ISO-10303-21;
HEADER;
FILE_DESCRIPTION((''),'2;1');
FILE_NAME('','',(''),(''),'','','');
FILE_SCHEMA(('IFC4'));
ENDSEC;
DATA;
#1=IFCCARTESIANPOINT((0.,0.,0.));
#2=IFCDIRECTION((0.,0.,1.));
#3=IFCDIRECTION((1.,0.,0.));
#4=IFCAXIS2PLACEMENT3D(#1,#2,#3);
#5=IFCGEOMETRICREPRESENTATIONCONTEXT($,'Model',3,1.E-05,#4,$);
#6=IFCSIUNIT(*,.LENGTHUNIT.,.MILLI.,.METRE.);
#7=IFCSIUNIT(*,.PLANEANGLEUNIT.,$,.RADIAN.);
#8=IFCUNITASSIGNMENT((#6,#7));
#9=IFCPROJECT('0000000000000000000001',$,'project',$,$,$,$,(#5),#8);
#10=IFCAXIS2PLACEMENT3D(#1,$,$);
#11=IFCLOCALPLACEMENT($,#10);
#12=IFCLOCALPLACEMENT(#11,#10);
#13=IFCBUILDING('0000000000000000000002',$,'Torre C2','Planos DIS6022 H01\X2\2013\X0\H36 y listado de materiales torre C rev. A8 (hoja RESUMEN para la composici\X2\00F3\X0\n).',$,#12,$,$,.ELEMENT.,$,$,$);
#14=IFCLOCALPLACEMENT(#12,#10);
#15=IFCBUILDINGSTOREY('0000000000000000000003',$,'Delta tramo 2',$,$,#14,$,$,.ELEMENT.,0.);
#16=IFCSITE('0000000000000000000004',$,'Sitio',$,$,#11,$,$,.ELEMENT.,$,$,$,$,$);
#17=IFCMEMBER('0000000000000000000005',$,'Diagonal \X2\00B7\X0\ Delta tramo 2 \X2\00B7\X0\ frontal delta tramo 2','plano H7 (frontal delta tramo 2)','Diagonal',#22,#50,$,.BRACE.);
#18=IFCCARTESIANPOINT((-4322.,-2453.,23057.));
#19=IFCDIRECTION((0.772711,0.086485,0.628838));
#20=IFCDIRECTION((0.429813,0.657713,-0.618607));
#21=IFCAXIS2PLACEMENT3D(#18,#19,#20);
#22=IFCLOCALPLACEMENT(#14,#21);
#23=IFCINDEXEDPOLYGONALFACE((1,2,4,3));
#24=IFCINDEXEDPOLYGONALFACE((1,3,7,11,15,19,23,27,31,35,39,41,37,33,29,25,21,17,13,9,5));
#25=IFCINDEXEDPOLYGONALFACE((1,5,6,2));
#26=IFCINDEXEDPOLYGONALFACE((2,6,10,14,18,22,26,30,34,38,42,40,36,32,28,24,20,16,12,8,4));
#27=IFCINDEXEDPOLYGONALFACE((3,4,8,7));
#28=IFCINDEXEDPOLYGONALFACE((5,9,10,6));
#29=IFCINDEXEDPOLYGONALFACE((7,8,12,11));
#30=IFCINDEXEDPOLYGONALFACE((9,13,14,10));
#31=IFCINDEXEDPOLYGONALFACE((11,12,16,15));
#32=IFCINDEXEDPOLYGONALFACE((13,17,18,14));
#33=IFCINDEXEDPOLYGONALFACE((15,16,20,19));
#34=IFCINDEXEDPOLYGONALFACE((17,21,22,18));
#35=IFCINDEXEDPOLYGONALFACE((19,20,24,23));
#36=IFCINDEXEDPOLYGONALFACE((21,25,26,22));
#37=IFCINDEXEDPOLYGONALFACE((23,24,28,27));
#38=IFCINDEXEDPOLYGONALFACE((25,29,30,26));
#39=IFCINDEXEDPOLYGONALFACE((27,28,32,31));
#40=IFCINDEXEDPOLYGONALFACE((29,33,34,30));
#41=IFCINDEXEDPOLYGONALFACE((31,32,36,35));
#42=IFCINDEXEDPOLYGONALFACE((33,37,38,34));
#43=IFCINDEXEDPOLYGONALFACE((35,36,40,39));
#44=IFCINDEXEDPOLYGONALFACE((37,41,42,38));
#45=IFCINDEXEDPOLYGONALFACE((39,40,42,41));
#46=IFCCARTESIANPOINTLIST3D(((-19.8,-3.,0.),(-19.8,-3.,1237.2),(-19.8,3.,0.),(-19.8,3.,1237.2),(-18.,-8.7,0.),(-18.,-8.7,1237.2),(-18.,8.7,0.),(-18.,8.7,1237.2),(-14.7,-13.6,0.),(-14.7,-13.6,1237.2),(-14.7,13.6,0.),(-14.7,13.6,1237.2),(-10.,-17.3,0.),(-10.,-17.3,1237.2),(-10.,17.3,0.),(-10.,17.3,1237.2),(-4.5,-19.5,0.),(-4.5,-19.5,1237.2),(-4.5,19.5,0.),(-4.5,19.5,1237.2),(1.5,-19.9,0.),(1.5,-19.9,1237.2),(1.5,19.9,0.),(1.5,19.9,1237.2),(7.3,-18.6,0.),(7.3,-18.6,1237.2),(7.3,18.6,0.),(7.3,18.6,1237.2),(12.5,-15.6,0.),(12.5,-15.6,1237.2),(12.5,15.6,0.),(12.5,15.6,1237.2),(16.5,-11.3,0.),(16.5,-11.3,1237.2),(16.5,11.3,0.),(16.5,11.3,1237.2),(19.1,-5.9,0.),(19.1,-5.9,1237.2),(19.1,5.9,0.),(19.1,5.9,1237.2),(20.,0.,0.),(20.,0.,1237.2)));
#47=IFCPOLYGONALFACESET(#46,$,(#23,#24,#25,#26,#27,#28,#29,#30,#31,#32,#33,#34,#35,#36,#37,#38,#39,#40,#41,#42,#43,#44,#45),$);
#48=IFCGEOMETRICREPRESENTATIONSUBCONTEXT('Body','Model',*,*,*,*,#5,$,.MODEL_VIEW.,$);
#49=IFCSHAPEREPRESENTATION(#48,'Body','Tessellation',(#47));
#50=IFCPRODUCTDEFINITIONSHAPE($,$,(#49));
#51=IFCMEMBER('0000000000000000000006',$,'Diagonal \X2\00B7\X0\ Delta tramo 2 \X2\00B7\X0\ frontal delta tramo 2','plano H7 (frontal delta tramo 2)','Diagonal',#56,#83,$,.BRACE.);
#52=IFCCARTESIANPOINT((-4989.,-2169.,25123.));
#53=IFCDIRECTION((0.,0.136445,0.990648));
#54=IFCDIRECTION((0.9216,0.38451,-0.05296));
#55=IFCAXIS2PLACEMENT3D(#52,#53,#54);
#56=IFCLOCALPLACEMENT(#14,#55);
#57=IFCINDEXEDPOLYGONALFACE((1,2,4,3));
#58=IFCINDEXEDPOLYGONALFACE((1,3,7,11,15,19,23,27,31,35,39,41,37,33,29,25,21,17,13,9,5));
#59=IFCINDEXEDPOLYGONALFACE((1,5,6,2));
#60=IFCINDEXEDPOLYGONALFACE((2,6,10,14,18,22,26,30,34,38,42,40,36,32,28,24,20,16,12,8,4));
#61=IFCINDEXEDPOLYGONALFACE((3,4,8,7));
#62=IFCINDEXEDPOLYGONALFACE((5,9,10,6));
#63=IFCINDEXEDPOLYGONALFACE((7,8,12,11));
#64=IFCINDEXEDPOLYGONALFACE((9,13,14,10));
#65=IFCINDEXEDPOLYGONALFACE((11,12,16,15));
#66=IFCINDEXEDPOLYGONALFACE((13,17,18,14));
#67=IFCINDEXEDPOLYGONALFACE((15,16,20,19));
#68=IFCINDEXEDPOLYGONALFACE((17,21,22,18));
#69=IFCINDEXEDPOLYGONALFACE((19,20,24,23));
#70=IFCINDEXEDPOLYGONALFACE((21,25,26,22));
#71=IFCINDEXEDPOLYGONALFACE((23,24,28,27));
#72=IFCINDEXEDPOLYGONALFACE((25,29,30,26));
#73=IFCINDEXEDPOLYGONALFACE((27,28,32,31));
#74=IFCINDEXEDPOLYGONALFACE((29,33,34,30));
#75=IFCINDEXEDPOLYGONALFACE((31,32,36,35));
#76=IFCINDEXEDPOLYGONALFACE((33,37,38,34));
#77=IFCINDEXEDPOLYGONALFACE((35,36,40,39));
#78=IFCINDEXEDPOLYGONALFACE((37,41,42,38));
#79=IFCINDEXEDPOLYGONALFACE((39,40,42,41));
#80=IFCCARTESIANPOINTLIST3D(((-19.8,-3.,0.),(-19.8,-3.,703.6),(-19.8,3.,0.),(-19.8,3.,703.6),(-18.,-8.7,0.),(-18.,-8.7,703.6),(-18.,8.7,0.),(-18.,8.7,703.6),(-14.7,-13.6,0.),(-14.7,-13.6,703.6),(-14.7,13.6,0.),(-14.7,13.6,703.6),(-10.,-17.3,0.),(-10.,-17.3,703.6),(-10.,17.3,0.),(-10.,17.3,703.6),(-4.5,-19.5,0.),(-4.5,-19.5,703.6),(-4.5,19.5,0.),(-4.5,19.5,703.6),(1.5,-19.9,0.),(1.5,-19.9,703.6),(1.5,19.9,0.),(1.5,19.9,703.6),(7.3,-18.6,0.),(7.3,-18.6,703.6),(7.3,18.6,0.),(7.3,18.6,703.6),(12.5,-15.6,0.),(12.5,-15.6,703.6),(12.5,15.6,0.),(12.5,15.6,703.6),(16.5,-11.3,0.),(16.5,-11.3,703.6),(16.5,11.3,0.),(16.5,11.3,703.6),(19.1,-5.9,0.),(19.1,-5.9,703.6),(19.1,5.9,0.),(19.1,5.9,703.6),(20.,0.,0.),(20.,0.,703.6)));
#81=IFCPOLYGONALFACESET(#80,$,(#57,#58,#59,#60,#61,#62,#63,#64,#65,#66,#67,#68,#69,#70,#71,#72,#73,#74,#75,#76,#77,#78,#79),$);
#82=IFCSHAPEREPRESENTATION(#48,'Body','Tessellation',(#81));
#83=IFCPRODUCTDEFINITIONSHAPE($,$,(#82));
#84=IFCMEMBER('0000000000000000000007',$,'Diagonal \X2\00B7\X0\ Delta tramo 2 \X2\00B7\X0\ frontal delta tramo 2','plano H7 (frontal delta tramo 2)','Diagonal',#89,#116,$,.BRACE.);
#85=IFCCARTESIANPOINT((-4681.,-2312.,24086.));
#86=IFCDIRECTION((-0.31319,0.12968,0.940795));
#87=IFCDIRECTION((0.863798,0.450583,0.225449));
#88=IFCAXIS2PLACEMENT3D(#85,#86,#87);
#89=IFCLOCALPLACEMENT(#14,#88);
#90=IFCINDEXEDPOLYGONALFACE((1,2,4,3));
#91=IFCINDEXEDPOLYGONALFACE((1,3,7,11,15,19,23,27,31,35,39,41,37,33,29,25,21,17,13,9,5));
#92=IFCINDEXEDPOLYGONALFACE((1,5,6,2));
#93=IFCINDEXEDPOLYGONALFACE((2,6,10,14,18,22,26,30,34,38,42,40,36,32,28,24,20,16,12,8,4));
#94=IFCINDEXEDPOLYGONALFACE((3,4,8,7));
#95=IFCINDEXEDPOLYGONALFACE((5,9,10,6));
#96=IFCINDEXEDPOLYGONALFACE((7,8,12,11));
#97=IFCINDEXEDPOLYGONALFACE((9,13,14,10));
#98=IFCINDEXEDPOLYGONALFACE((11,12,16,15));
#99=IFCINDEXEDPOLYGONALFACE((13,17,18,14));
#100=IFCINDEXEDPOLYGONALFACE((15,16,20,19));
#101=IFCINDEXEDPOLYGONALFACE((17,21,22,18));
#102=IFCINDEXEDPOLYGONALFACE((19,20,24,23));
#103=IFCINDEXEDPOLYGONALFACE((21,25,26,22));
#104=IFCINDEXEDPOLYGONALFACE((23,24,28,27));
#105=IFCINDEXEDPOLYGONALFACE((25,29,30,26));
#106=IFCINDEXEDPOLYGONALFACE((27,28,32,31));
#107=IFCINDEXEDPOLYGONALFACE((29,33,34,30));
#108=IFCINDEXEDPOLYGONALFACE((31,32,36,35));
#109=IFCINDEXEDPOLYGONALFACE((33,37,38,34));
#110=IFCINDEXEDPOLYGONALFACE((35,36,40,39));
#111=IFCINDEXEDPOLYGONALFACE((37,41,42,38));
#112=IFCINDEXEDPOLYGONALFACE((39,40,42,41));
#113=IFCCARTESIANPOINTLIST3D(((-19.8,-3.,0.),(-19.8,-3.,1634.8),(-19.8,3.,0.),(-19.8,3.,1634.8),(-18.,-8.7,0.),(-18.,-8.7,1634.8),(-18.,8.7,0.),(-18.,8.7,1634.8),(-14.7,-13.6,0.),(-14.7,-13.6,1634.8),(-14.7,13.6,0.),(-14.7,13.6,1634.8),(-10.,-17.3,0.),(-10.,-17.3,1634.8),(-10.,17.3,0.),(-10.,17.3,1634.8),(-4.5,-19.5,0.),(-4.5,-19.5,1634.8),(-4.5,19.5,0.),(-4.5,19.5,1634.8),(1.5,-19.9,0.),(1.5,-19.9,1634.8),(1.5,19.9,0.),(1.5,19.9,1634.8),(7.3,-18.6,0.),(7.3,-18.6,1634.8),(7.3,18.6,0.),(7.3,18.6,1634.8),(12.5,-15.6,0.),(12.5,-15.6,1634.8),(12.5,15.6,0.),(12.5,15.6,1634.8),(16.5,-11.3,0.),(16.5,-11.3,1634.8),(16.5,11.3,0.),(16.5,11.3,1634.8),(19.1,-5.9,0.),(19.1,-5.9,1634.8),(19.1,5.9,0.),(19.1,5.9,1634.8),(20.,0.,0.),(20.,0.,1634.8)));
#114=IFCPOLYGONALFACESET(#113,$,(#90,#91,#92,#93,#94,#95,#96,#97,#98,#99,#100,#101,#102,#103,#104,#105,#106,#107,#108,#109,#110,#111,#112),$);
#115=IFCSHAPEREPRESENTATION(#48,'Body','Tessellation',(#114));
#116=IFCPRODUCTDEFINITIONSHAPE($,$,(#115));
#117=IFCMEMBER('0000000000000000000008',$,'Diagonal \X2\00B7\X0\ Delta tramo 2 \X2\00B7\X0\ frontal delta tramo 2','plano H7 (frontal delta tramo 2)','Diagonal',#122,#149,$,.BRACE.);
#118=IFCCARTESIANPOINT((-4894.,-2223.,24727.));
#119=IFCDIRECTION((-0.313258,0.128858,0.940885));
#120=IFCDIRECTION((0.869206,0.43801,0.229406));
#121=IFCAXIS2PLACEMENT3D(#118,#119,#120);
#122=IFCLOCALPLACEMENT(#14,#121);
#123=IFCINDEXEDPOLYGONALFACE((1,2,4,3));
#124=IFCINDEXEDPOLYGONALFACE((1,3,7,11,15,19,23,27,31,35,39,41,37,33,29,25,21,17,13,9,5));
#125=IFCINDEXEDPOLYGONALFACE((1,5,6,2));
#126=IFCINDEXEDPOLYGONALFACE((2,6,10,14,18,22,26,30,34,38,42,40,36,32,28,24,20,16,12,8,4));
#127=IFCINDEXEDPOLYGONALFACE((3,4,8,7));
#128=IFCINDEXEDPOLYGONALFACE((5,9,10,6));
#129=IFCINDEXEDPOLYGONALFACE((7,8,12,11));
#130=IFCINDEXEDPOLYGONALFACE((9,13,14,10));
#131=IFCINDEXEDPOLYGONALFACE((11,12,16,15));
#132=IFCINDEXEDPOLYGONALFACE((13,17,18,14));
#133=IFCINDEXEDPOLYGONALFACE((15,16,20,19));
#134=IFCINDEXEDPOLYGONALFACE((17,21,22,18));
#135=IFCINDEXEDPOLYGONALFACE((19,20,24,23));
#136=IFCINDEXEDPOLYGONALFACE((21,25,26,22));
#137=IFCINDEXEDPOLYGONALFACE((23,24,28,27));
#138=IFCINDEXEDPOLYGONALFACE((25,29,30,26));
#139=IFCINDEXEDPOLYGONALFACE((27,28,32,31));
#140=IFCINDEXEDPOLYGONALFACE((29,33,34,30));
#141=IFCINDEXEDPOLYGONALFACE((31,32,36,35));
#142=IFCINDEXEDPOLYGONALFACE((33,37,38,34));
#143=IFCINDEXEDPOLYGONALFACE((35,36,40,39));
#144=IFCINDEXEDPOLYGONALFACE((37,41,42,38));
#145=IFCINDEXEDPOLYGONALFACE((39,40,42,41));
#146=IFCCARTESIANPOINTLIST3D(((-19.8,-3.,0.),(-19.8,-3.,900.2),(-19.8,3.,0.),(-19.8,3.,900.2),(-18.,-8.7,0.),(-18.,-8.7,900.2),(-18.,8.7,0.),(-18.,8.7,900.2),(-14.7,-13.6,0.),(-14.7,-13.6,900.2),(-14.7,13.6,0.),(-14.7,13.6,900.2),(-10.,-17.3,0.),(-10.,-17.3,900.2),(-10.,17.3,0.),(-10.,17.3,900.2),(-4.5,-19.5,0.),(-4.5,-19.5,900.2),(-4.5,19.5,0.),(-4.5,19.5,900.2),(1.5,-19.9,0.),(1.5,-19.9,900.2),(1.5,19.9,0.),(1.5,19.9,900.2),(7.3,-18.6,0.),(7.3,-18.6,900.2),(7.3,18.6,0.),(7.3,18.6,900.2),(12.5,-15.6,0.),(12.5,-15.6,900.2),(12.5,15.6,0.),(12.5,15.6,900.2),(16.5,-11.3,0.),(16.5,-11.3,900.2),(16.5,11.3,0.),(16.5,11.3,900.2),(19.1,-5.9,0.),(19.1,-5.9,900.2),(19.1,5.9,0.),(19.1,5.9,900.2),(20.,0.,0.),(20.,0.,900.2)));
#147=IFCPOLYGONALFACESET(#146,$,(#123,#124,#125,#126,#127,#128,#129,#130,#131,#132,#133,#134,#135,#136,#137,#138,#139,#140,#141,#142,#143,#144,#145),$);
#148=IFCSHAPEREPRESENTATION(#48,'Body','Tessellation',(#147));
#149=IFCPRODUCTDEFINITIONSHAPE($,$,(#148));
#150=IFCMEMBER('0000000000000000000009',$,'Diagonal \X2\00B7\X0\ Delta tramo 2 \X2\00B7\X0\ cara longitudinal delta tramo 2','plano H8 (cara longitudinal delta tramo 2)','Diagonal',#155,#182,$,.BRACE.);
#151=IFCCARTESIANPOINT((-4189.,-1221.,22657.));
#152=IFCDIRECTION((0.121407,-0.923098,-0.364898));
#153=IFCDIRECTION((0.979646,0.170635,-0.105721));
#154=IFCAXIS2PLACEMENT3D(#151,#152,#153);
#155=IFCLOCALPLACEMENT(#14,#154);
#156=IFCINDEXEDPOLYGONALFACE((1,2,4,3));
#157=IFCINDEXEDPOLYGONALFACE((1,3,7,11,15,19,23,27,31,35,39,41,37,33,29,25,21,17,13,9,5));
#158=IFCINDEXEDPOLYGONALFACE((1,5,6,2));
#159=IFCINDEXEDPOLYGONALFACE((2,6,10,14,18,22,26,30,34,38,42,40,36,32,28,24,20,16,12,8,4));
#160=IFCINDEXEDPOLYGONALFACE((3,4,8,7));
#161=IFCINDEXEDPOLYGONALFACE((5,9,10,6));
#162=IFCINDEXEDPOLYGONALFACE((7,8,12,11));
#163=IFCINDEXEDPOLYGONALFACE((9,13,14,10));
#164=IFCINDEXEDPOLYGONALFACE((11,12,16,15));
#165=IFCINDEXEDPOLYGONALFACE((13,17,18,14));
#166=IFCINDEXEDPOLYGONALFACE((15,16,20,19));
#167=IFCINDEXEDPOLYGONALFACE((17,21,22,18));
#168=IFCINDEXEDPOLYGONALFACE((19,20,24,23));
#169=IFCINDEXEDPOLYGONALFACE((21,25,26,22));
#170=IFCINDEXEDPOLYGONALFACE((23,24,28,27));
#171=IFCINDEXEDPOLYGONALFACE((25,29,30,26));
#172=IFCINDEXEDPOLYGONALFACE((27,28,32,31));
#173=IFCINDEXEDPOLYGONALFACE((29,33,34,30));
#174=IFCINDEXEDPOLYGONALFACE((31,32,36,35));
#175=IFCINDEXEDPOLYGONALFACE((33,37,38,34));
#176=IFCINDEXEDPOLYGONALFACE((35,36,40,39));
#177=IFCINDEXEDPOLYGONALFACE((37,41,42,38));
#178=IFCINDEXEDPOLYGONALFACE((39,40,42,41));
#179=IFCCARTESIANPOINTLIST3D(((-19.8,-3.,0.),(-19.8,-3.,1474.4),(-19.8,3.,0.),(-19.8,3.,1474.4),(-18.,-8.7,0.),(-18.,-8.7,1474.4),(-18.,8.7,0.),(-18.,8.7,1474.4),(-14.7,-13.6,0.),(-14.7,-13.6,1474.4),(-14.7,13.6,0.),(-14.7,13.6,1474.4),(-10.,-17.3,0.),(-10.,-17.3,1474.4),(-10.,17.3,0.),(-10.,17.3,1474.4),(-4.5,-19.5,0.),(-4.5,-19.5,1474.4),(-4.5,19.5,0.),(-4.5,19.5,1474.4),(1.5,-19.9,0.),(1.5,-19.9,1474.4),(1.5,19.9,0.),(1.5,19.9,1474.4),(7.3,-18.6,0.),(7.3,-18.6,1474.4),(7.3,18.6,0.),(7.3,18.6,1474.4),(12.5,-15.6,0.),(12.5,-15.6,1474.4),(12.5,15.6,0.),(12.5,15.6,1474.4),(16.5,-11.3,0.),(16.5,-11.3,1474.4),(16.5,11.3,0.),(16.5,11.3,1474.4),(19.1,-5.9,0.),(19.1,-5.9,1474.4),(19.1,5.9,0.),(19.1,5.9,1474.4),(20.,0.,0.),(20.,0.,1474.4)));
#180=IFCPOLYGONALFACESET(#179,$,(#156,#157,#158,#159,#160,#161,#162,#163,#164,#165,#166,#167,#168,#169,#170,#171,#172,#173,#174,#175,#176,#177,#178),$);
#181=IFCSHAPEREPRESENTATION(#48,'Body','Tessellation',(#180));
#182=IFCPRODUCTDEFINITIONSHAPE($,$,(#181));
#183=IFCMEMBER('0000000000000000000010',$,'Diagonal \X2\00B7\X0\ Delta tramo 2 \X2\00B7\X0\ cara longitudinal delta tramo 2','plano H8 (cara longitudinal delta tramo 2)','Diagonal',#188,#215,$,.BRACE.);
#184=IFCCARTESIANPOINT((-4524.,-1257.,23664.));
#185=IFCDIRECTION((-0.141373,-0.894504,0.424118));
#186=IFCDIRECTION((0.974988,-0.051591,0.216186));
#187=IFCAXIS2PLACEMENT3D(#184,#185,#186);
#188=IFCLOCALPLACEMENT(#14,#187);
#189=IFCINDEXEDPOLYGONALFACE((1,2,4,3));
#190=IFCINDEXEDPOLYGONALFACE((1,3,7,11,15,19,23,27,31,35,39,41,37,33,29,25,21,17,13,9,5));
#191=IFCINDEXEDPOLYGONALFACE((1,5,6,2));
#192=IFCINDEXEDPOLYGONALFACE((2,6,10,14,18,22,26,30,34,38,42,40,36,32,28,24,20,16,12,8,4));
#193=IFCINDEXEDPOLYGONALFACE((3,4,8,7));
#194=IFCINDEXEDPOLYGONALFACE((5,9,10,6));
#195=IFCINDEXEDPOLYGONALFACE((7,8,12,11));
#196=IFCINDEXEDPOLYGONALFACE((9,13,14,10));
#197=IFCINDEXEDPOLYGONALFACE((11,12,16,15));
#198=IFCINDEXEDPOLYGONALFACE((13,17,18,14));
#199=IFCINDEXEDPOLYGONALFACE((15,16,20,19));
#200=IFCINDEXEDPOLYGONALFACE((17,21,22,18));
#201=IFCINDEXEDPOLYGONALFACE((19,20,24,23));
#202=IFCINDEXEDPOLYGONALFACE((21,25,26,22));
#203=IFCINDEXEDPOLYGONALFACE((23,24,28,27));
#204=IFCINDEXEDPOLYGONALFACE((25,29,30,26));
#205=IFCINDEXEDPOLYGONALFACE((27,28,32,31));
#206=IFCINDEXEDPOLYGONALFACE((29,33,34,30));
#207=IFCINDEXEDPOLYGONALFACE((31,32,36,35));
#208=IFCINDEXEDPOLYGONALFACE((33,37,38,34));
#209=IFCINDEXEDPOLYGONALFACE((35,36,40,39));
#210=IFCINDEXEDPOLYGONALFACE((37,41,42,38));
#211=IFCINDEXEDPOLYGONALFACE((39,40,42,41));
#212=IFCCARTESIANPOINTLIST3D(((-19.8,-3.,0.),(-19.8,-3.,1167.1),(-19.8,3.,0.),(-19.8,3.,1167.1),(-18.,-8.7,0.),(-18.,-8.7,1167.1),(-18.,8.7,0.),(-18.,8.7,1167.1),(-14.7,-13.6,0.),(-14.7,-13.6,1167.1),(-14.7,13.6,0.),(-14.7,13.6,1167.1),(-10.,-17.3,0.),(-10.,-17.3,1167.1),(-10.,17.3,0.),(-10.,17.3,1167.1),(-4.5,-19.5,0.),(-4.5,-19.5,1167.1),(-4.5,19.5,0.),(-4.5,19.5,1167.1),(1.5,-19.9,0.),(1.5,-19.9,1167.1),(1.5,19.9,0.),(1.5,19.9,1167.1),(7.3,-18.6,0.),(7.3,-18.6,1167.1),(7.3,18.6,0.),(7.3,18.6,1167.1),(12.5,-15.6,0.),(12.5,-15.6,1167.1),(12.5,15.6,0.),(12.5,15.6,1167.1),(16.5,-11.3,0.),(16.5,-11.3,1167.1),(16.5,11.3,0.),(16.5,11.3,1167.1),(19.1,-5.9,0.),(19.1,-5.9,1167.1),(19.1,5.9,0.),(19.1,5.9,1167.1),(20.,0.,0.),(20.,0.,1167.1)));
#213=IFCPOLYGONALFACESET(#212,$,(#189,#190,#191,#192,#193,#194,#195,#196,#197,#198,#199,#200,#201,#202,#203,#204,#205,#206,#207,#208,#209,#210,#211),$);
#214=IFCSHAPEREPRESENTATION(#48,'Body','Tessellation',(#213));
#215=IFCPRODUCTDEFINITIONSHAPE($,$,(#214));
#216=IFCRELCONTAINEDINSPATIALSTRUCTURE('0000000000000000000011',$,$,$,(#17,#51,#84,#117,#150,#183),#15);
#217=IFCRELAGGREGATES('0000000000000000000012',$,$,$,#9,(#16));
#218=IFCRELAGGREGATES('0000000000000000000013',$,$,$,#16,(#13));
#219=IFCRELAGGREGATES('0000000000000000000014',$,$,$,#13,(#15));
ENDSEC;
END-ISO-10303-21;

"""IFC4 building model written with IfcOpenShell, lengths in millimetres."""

from ifc_helpers import new_model, si_unit, frame, origin, origin_with_axes, place, context, subcontext, project, spatial, circle, extrude, element, save


model = new_model("IFC4")

# Units and contexts
model_context = context("Model", 3, precision=1e-05, world=origin_with_axes())
body_context = subcontext(model_context, "Body", "Model", "MODEL_VIEW")
ifc_project = project(units=[si_unit("LENGTHUNIT", "METRE", prefix="MILLI"), si_unit("PLANEANGLEUNIT", "RADIAN")], contexts=[model_context])

# Site, building, storey
site_placement = place(None, origin())
site = spatial("IfcSite", under=ifc_project, at=site_placement, Name="Sitio", CompositionType="ELEMENT")
building_placement = place(site_placement, origin())
building = spatial("IfcBuilding", under=site, at=building_placement, Name="Torre C2", Description="Planos DIS6022 H01–H36 y listado de materiales torre C rev. A8 (hoja RESUMEN para la composición).", CompositionType="ELEMENT")
storey_placement = place(building_placement, origin())
storey = spatial("IfcBuildingStorey", under=building, at=storey_placement, Name="Delta tramo 2", CompositionType="ELEMENT", Elevation=0.0)

# Members
member_1_placement = place(storey_placement, frame((-4322.0, -2453.0, 23057.0), z_axis=(0.772711, 0.086485, 0.628838), x_axis=(0.429813, 0.657713, -0.618607)))
element("IfcMember", 1, at=member_1_placement, inside=storey, Name="Diagonal · Delta tramo 2 · frontal delta tramo 2", Description="plano H7 (frontal delta tramo 2)", ObjectType="Diagonal", PredefinedType="BRACE", context=body_context, shape_type="SweptSolid", body=[
    extrude(circle(Radius=20.0), None, (0.0, 0.0, 1.0), 1237.2),
])
member_2_placement = place(storey_placement, frame((-4989.0, -2169.0, 25123.0), z_axis=(0.0, 0.136445, 0.990648), x_axis=(0.9216, 0.38451, -0.05296)))
element("IfcMember", 2, at=member_2_placement, inside=storey, Name="Diagonal · Delta tramo 2 · frontal delta tramo 2", Description="plano H7 (frontal delta tramo 2)", ObjectType="Diagonal", PredefinedType="BRACE", context=body_context, shape_type="SweptSolid", body=[
    extrude(circle(Radius=20.0), None, (0.0, 0.0, 1.0), 703.6),
])
member_3_placement = place(storey_placement, frame((-4681.0, -2312.0, 24086.0), z_axis=(-0.31319, 0.12968, 0.940795), x_axis=(0.863798, 0.450583, 0.225449)))
element("IfcMember", 3, at=member_3_placement, inside=storey, Name="Diagonal · Delta tramo 2 · frontal delta tramo 2", Description="plano H7 (frontal delta tramo 2)", ObjectType="Diagonal", PredefinedType="BRACE", context=body_context, shape_type="SweptSolid", body=[
    extrude(circle(Radius=20.0), None, (0.0, 0.0, 1.0), 1634.8),
])
member_4_placement = place(storey_placement, frame((-4894.0, -2223.0, 24727.0), z_axis=(-0.313258, 0.128858, 0.940885), x_axis=(0.869206, 0.43801, 0.229406)))
element("IfcMember", 4, at=member_4_placement, inside=storey, Name="Diagonal · Delta tramo 2 · frontal delta tramo 2", Description="plano H7 (frontal delta tramo 2)", ObjectType="Diagonal", PredefinedType="BRACE", context=body_context, shape_type="SweptSolid", body=[
    extrude(circle(Radius=20.0), None, (0.0, 0.0, 1.0), 900.2),
])
member_5_placement = place(storey_placement, frame((-4189.0, -1221.0, 22657.0), z_axis=(0.121407, -0.923098, -0.364898), x_axis=(0.979646, 0.170635, -0.105721)))
element("IfcMember", 5, at=member_5_placement, inside=storey, Name="Diagonal · Delta tramo 2 · cara longitudinal delta tramo 2", Description="plano H8 (cara longitudinal delta tramo 2)", ObjectType="Diagonal", PredefinedType="BRACE", context=body_context, shape_type="SweptSolid", body=[
    extrude(circle(Radius=20.0), None, (0.0, 0.0, 1.0), 1474.4),
])
member_6_placement = place(storey_placement, frame((-4524.0, -1257.0, 23664.0), z_axis=(-0.141373, -0.894504, 0.424118), x_axis=(0.974988, -0.051591, 0.216186)))
element("IfcMember", 6, at=member_6_placement, inside=storey, Name="Diagonal · Delta tramo 2 · cara longitudinal delta tramo 2", Description="plano H8 (cara longitudinal delta tramo 2)", ObjectType="Diagonal", PredefinedType="BRACE", context=body_context, shape_type="SweptSolid", body=[
    extrude(circle(Radius=20.0), None, (0.0, 0.0, 1.0), 1167.1),
])

save(model, "model.ifc")
